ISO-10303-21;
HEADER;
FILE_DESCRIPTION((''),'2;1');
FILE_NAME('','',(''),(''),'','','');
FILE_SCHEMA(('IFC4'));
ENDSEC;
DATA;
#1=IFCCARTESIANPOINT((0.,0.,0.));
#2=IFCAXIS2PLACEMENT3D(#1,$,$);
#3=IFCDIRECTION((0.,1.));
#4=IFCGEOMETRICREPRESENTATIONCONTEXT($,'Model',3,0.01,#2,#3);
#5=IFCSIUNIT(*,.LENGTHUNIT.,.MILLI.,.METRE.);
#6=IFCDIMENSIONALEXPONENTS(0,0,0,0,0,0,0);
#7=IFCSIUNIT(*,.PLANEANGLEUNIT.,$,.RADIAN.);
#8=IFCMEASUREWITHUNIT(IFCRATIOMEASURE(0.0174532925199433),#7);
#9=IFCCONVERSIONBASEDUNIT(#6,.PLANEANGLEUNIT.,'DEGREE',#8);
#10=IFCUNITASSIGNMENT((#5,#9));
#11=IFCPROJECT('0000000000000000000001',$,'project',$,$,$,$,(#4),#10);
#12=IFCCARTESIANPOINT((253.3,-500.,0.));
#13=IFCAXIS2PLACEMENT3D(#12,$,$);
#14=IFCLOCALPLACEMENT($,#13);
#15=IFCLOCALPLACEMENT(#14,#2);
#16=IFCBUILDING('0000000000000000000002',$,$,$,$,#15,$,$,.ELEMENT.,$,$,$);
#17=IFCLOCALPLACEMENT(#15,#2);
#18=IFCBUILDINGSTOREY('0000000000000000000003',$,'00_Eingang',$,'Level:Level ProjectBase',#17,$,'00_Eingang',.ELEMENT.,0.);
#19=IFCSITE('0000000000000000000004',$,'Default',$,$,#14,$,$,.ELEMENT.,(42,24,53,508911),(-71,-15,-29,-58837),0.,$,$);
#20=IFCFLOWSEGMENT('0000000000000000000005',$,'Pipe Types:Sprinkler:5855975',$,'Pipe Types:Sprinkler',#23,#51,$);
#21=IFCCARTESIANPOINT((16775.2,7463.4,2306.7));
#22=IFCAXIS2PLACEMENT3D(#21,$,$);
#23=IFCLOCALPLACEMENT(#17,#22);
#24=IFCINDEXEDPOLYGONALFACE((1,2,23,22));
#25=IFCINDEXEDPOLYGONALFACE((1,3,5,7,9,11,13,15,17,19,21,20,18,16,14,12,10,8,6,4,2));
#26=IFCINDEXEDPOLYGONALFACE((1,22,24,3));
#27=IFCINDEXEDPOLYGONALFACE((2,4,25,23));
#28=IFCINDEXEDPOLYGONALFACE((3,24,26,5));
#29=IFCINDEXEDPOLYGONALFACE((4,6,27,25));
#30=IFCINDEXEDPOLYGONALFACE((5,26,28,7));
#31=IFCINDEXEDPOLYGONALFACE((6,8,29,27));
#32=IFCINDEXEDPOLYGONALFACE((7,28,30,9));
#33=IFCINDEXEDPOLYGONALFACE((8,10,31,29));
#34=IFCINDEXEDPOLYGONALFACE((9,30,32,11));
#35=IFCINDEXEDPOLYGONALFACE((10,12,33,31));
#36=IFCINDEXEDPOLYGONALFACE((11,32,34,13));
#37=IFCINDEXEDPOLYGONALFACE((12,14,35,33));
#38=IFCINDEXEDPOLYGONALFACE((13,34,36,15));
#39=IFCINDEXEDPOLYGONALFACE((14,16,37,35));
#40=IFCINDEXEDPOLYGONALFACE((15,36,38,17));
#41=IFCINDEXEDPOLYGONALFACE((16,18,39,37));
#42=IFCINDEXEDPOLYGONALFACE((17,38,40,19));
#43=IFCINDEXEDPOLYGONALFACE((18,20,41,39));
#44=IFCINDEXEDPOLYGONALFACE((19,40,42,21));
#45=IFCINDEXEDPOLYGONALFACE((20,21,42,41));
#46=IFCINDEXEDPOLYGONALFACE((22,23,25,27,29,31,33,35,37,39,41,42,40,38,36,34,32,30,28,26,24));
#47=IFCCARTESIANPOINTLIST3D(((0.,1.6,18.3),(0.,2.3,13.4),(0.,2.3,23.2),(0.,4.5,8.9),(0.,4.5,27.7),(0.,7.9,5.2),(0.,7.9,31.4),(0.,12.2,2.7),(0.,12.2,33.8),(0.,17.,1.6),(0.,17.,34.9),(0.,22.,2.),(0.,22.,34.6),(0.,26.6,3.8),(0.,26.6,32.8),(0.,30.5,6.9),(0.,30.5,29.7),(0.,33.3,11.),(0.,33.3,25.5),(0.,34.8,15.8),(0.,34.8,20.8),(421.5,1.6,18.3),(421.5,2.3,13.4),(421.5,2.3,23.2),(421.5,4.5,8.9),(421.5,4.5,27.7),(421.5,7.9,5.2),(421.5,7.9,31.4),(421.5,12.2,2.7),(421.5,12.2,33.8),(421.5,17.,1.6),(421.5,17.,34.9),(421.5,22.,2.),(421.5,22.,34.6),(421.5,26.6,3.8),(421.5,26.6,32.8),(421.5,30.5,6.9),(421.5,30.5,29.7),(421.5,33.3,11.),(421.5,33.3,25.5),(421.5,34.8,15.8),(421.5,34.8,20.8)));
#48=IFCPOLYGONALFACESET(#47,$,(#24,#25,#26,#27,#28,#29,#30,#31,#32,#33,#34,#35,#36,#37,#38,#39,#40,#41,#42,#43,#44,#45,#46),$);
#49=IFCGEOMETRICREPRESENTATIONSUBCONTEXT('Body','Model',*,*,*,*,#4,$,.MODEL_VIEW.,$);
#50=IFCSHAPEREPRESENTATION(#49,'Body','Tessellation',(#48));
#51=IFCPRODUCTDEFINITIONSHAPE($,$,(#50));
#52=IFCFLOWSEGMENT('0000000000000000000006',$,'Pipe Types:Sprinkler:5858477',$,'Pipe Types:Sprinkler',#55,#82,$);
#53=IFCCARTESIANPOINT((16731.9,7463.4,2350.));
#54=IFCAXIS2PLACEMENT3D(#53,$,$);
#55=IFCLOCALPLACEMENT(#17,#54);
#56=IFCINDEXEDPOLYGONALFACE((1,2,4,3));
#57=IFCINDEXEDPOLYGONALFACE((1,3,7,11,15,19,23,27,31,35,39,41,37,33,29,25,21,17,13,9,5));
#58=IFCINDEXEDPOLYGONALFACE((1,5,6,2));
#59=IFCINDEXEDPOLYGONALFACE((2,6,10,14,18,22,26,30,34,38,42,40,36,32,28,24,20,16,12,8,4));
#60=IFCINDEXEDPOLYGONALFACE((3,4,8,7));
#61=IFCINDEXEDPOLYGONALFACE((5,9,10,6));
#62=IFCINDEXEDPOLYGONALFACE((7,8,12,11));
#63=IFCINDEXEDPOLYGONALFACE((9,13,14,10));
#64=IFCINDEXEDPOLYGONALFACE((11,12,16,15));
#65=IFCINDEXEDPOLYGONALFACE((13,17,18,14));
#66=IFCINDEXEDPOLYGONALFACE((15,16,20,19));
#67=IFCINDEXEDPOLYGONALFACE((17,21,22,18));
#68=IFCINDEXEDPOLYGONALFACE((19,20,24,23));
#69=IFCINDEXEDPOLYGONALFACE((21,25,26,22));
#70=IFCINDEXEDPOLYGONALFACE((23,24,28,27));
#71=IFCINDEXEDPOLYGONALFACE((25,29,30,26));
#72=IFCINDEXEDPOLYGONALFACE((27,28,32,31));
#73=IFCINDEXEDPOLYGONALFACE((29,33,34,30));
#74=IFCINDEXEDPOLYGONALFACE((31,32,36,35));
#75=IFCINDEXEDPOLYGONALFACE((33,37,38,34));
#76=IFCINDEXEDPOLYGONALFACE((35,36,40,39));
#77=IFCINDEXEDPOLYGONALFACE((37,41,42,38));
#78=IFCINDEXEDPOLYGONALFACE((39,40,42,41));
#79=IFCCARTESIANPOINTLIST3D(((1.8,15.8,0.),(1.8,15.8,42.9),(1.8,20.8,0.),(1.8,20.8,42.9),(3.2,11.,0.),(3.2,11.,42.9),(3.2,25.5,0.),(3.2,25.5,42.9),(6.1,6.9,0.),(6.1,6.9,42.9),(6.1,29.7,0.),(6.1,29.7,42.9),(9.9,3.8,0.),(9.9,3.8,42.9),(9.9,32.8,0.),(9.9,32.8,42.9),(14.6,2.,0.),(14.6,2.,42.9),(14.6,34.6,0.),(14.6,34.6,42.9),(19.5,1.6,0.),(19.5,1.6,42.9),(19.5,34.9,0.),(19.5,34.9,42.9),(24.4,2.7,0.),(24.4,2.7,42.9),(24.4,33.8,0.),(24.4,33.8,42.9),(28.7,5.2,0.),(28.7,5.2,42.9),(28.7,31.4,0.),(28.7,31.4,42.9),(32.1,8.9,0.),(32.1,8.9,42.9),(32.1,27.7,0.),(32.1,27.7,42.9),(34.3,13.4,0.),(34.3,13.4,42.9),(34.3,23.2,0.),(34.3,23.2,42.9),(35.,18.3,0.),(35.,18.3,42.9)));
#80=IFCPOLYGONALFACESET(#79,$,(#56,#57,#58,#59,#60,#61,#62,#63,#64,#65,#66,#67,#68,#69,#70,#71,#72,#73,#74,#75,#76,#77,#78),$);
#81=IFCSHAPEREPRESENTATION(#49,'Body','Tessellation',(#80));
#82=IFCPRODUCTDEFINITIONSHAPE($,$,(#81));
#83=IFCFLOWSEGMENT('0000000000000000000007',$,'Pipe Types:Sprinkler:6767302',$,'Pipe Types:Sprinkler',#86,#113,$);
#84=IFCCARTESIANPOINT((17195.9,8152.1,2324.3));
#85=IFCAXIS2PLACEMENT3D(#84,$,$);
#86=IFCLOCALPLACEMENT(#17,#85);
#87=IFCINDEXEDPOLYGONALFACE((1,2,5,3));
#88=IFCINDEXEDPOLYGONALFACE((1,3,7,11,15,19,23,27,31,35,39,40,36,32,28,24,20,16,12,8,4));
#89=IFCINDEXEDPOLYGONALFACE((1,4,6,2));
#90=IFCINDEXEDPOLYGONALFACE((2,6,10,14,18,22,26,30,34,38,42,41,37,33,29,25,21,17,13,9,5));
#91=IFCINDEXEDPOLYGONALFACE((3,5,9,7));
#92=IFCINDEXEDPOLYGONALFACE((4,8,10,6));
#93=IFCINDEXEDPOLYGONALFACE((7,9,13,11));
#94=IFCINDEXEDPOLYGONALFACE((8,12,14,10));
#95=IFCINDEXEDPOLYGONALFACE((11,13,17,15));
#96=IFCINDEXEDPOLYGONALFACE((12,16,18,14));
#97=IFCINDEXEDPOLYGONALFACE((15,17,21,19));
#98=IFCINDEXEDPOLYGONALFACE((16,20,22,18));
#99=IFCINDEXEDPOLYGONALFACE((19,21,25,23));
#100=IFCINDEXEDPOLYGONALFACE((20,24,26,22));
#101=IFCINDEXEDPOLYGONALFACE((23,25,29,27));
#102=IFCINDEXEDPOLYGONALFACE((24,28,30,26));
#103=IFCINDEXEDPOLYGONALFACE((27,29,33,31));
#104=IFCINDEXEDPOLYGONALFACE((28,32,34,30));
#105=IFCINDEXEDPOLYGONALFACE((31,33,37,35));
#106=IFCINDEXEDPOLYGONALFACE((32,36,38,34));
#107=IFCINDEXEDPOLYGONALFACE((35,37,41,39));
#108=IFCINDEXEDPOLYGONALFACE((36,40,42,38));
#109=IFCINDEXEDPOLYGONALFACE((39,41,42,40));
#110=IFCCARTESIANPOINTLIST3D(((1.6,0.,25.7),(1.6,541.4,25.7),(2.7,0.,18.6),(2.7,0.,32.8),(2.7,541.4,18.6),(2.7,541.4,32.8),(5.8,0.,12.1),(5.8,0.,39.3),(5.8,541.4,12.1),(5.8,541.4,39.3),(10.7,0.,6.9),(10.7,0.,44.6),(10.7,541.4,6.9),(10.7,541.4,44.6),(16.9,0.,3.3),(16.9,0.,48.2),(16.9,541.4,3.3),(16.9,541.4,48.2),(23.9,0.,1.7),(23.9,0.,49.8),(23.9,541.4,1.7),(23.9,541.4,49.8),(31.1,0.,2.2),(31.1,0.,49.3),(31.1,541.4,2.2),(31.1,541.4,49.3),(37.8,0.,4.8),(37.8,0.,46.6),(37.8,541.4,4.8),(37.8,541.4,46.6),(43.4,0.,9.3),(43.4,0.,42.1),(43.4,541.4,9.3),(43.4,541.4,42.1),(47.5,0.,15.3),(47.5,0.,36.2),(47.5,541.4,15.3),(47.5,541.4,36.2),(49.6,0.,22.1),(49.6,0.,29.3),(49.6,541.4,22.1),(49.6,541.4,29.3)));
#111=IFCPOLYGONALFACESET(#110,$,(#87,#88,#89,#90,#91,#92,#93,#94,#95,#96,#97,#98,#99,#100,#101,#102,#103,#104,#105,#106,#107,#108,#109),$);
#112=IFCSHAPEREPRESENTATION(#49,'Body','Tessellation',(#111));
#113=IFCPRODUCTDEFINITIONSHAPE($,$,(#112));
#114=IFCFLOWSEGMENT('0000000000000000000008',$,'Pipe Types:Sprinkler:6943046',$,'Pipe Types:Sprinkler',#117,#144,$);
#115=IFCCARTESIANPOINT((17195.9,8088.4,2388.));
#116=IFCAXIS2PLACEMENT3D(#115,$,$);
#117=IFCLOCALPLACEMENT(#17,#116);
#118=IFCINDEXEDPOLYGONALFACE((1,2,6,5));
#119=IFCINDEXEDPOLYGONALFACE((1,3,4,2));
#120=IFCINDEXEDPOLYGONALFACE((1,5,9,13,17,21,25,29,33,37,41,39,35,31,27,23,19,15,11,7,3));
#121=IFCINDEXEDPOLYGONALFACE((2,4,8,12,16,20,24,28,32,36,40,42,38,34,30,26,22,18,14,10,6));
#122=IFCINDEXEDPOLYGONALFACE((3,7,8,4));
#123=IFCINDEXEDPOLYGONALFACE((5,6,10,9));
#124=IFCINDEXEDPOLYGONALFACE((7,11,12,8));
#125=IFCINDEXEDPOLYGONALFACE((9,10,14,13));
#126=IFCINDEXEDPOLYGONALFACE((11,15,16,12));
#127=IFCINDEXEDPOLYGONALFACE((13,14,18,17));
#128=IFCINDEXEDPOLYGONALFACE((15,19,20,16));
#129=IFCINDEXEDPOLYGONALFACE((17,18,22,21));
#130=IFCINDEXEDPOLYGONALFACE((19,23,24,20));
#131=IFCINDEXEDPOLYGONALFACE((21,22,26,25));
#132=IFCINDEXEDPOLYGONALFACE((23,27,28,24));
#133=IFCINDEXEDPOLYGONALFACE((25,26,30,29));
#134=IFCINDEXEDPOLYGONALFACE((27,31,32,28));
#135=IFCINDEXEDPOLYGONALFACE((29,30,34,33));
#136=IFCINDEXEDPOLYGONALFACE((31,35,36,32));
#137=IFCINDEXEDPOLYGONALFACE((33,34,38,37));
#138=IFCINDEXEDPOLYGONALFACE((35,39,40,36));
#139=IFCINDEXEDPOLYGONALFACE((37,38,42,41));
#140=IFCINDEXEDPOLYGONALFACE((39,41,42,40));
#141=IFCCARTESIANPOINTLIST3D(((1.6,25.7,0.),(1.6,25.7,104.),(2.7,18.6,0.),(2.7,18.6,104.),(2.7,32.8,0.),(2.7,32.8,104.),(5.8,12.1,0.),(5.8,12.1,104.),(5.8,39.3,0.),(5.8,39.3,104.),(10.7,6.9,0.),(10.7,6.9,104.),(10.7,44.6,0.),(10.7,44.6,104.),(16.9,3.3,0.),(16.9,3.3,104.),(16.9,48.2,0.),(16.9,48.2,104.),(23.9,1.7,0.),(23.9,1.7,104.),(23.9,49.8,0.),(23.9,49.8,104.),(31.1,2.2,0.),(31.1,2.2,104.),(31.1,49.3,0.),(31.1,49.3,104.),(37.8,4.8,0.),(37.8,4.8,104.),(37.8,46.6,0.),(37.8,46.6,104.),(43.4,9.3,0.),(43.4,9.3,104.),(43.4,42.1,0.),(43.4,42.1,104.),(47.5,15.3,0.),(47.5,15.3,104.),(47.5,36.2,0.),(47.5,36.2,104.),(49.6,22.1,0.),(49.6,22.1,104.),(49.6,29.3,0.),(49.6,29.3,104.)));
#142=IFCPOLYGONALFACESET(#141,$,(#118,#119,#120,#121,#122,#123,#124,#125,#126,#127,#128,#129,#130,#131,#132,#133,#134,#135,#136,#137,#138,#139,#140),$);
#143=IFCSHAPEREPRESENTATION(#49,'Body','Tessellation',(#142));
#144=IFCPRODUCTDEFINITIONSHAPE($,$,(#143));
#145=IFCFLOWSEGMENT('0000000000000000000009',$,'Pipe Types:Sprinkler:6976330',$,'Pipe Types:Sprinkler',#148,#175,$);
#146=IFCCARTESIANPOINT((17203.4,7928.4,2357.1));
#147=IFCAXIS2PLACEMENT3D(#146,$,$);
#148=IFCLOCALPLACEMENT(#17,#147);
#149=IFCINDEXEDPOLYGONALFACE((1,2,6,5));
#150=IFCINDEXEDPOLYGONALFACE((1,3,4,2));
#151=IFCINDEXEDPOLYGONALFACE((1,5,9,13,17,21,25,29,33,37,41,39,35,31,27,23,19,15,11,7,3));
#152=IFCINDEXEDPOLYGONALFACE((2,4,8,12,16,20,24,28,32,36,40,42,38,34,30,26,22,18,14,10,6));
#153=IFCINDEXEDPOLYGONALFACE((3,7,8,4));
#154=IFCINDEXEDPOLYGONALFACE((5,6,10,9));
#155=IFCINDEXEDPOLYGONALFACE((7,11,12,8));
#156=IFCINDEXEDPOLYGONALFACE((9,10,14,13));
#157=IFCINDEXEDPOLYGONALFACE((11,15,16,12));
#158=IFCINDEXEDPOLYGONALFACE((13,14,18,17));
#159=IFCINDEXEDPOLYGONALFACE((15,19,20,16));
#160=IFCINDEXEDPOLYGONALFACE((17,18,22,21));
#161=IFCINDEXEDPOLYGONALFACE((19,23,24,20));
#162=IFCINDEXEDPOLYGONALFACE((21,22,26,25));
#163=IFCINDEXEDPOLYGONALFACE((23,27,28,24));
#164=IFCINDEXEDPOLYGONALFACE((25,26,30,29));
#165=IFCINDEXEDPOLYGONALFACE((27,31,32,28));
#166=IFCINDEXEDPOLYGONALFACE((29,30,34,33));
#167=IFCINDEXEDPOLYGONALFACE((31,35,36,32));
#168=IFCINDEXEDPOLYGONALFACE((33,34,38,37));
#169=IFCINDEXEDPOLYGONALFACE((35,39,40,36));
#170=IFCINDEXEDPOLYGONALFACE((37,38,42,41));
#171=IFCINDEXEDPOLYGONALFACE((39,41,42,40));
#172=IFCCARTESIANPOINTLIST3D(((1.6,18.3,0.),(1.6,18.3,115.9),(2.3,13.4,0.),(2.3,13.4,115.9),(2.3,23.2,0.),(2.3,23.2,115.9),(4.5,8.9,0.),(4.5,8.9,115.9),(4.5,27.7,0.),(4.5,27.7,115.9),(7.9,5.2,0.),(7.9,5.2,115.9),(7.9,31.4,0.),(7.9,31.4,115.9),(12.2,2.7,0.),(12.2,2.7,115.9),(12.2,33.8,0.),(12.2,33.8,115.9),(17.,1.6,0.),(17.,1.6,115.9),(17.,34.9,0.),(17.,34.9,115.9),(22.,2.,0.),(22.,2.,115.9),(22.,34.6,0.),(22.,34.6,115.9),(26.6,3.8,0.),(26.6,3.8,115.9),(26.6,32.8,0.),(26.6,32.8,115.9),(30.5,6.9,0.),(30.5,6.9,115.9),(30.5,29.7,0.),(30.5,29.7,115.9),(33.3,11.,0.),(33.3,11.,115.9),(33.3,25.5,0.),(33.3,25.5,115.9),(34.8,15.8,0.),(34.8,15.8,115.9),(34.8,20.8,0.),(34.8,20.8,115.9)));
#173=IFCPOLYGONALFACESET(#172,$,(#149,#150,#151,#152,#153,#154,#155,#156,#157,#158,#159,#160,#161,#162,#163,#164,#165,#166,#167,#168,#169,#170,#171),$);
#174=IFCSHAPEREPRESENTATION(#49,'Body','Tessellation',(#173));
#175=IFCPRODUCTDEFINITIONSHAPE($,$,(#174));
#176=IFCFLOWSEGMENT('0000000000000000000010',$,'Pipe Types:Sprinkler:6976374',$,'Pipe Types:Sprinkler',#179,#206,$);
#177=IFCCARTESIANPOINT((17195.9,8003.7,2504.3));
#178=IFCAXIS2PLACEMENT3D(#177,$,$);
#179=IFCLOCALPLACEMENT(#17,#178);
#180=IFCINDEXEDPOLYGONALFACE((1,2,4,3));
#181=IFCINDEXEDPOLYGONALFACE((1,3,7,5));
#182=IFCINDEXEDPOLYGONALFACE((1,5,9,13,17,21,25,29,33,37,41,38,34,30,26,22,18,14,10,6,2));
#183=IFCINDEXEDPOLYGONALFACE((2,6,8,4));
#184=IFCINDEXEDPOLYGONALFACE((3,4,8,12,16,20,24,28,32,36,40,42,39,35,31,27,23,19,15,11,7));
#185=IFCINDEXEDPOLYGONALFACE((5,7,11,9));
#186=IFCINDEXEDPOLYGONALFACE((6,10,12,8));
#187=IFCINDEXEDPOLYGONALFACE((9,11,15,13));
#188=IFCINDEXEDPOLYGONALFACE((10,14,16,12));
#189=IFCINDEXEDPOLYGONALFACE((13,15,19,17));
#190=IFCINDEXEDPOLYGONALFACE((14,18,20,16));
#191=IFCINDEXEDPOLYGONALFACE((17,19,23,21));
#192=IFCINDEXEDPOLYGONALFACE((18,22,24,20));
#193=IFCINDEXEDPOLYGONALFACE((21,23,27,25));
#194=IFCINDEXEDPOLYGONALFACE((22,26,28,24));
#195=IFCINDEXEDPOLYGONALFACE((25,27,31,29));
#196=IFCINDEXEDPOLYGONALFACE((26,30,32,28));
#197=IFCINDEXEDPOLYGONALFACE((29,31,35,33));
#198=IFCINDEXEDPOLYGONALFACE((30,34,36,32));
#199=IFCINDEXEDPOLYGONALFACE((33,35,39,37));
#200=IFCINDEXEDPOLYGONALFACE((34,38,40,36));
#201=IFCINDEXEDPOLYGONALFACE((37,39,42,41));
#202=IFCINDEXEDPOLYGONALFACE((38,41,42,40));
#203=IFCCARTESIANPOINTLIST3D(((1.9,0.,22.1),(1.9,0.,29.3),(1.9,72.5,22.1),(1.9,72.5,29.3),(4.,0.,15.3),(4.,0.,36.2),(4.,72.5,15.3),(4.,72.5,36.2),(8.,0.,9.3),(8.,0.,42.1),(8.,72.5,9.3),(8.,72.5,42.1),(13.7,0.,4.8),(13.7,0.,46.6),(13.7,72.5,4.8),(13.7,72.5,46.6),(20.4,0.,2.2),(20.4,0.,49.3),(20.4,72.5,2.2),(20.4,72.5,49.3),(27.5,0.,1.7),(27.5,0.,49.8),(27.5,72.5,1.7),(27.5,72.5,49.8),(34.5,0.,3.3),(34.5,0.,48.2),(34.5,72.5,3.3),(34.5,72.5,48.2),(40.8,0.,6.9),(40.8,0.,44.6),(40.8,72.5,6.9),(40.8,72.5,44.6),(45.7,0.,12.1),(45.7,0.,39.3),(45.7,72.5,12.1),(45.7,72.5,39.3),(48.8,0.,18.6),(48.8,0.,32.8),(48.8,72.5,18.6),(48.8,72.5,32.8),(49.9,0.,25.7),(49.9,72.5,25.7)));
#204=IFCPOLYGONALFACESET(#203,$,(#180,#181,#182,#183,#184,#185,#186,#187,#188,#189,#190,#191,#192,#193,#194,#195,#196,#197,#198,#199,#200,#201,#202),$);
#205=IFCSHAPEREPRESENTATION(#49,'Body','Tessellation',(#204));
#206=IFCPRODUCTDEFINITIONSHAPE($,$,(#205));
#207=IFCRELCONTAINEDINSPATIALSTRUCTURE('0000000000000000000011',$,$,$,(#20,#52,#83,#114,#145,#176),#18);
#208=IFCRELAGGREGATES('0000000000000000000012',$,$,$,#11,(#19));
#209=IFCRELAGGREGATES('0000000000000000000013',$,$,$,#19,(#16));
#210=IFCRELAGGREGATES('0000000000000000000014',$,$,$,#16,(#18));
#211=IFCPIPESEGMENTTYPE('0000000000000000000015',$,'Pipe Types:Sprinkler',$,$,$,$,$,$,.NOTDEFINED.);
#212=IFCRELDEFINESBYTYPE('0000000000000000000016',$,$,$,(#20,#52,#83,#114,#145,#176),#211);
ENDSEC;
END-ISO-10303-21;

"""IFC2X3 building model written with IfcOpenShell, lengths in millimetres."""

from ifc_helpers import new_model, entity, si_unit, converted_unit, direction, frame, frame_2d, origin, origin_2d_with_axis, place, context, subcontext, project, spatial, circle, extrude, type_object, element, save


model = new_model("IFC2X3")

# Units and contexts
model_context = context("Model", 3, precision=0.01, world=origin(), true_north=direction((0.0, 1.0)))
body_context = subcontext(model_context, "Body", "Model", "MODEL_VIEW")
ifc_project = project(units=[si_unit("LENGTHUNIT", "METRE", prefix="MILLI"), converted_unit("PLANEANGLEUNIT", "DEGREE", entity("IfcRatioMeasure", 0.0174532925199433), si_unit("PLANEANGLEUNIT", "RADIAN"), dimensions=[0, 0, 0, 0, 0, 0, 0])], contexts=[model_context])

# Site, building, storey
site_placement = place(None, frame((253.3, -500.0, 0.0)))
site = spatial("IfcSite", under=ifc_project, at=site_placement, Name="Default", CompositionType="ELEMENT", RefLatitude=(42, 24, 53, 508911), RefLongitude=(-71, -15, -29, -58837), RefElevation=0.0)
building_placement = place(site_placement, origin())
building = spatial("IfcBuilding", under=site, at=building_placement, CompositionType="ELEMENT")
storey_placement = place(building_placement, origin())
storey = spatial("IfcBuildingStorey", under=building, at=storey_placement, Name="00_Eingang", ObjectType="Level:Level ProjectBase", LongName="00_Eingang", CompositionType="ELEMENT", Elevation=0.0)

# Flow segments
pipe_segment_type = type_object("IfcPipeSegmentType", Name="Pipe Types:Sprinkler", PredefinedType="NOTDEFINED")
flow_segment_1_placement = place(storey_placement, frame((16775.2, 7463.4, 2306.7)))
element("IfcFlowSegment", 1, at=flow_segment_1_placement, inside=storey, type_object=pipe_segment_type, Name="Pipe Types:Sprinkler:5855975", ObjectType="Pipe Types:Sprinkler", context=body_context, shape_type="SweptSolid", body=[
    extrude(circle(Radius=16.7, at=origin_2d_with_axis()), frame((0.0, 18.3, 18.3), z_axis=(1.0, 0.0, 0.0), x_axis=(0.0, -1.0, 0.0)), (0.0, 0.0, 1.0), 421.5),
])
flow_segment_2_placement = place(storey_placement, frame((16731.9, 7463.4, 2350.0)))
element("IfcFlowSegment", 2, at=flow_segment_2_placement, inside=storey, type_object=pipe_segment_type, Name="Pipe Types:Sprinkler:5858477", ObjectType="Pipe Types:Sprinkler", context=body_context, shape_type="SweptSolid", body=[
    extrude(circle(Radius=16.7, at=origin_2d_with_axis()), frame((18.3, 18.3, 0.0)), (0.0, 0.0, 1.0), 42.9),
])
flow_segment_3_placement = place(storey_placement, frame((17195.9, 8152.1, 2324.3)))
element("IfcFlowSegment", 3, at=flow_segment_3_placement, inside=storey, type_object=pipe_segment_type, Name="Pipe Types:Sprinkler:6767302", ObjectType="Pipe Types:Sprinkler", context=body_context, shape_type="SweptSolid", body=[
    extrude(circle(Radius=24.1, at=frame_2d((0.0, 0.0), x_axis=(1.0, 0.0))), frame((25.7, 0.0, 25.7), z_axis=(0.0, 1.0, 0.0), x_axis=(-1.0, 0.0, 0.0)), (0.0, 0.0, 1.0), 541.4),
])
flow_segment_4_placement = place(storey_placement, frame((17195.9, 8088.4, 2388.0)))
element("IfcFlowSegment", 4, at=flow_segment_4_placement, inside=storey, type_object=pipe_segment_type, Name="Pipe Types:Sprinkler:6943046", ObjectType="Pipe Types:Sprinkler", context=body_context, shape_type="SweptSolid", body=[
    extrude(circle(Radius=24.1, at=origin_2d_with_axis()), frame((25.7, 25.7, 0.0), z_axis=(0.0, 0.0, 1.0), x_axis=(-1.0, 0.0, 0.0)), (0.0, 0.0, 1.0), 104.0),
])
flow_segment_5_placement = place(storey_placement, frame((17203.4, 7928.4, 2357.1)))
element("IfcFlowSegment", 5, at=flow_segment_5_placement, inside=storey, type_object=pipe_segment_type, Name="Pipe Types:Sprinkler:6976330", ObjectType="Pipe Types:Sprinkler", context=body_context, shape_type="SweptSolid", body=[
    extrude(circle(Radius=16.7, at=origin_2d_with_axis()), frame((18.3, 18.3, 0.0), z_axis=(0.0, 0.0, 1.0), x_axis=(-1.0, 0.0, 0.0)), (0.0, 0.0, 1.0), 115.9),
])
flow_segment_6_placement = place(storey_placement, frame((17195.9, 8003.7, 2504.3)))
element("IfcFlowSegment", 6, at=flow_segment_6_placement, inside=storey, type_object=pipe_segment_type, Name="Pipe Types:Sprinkler:6976374", ObjectType="Pipe Types:Sprinkler", context=body_context, shape_type="SweptSolid", body=[
    extrude(circle(Radius=24.1, at=origin_2d_with_axis()), frame((25.7, 0.0, 25.7), z_axis=(0.0, 1.0, 0.0), x_axis=(1.0, 0.0, 0.0)), (0.0, 0.0, 1.0), 72.5),
])

save(model, "model.ifc")
